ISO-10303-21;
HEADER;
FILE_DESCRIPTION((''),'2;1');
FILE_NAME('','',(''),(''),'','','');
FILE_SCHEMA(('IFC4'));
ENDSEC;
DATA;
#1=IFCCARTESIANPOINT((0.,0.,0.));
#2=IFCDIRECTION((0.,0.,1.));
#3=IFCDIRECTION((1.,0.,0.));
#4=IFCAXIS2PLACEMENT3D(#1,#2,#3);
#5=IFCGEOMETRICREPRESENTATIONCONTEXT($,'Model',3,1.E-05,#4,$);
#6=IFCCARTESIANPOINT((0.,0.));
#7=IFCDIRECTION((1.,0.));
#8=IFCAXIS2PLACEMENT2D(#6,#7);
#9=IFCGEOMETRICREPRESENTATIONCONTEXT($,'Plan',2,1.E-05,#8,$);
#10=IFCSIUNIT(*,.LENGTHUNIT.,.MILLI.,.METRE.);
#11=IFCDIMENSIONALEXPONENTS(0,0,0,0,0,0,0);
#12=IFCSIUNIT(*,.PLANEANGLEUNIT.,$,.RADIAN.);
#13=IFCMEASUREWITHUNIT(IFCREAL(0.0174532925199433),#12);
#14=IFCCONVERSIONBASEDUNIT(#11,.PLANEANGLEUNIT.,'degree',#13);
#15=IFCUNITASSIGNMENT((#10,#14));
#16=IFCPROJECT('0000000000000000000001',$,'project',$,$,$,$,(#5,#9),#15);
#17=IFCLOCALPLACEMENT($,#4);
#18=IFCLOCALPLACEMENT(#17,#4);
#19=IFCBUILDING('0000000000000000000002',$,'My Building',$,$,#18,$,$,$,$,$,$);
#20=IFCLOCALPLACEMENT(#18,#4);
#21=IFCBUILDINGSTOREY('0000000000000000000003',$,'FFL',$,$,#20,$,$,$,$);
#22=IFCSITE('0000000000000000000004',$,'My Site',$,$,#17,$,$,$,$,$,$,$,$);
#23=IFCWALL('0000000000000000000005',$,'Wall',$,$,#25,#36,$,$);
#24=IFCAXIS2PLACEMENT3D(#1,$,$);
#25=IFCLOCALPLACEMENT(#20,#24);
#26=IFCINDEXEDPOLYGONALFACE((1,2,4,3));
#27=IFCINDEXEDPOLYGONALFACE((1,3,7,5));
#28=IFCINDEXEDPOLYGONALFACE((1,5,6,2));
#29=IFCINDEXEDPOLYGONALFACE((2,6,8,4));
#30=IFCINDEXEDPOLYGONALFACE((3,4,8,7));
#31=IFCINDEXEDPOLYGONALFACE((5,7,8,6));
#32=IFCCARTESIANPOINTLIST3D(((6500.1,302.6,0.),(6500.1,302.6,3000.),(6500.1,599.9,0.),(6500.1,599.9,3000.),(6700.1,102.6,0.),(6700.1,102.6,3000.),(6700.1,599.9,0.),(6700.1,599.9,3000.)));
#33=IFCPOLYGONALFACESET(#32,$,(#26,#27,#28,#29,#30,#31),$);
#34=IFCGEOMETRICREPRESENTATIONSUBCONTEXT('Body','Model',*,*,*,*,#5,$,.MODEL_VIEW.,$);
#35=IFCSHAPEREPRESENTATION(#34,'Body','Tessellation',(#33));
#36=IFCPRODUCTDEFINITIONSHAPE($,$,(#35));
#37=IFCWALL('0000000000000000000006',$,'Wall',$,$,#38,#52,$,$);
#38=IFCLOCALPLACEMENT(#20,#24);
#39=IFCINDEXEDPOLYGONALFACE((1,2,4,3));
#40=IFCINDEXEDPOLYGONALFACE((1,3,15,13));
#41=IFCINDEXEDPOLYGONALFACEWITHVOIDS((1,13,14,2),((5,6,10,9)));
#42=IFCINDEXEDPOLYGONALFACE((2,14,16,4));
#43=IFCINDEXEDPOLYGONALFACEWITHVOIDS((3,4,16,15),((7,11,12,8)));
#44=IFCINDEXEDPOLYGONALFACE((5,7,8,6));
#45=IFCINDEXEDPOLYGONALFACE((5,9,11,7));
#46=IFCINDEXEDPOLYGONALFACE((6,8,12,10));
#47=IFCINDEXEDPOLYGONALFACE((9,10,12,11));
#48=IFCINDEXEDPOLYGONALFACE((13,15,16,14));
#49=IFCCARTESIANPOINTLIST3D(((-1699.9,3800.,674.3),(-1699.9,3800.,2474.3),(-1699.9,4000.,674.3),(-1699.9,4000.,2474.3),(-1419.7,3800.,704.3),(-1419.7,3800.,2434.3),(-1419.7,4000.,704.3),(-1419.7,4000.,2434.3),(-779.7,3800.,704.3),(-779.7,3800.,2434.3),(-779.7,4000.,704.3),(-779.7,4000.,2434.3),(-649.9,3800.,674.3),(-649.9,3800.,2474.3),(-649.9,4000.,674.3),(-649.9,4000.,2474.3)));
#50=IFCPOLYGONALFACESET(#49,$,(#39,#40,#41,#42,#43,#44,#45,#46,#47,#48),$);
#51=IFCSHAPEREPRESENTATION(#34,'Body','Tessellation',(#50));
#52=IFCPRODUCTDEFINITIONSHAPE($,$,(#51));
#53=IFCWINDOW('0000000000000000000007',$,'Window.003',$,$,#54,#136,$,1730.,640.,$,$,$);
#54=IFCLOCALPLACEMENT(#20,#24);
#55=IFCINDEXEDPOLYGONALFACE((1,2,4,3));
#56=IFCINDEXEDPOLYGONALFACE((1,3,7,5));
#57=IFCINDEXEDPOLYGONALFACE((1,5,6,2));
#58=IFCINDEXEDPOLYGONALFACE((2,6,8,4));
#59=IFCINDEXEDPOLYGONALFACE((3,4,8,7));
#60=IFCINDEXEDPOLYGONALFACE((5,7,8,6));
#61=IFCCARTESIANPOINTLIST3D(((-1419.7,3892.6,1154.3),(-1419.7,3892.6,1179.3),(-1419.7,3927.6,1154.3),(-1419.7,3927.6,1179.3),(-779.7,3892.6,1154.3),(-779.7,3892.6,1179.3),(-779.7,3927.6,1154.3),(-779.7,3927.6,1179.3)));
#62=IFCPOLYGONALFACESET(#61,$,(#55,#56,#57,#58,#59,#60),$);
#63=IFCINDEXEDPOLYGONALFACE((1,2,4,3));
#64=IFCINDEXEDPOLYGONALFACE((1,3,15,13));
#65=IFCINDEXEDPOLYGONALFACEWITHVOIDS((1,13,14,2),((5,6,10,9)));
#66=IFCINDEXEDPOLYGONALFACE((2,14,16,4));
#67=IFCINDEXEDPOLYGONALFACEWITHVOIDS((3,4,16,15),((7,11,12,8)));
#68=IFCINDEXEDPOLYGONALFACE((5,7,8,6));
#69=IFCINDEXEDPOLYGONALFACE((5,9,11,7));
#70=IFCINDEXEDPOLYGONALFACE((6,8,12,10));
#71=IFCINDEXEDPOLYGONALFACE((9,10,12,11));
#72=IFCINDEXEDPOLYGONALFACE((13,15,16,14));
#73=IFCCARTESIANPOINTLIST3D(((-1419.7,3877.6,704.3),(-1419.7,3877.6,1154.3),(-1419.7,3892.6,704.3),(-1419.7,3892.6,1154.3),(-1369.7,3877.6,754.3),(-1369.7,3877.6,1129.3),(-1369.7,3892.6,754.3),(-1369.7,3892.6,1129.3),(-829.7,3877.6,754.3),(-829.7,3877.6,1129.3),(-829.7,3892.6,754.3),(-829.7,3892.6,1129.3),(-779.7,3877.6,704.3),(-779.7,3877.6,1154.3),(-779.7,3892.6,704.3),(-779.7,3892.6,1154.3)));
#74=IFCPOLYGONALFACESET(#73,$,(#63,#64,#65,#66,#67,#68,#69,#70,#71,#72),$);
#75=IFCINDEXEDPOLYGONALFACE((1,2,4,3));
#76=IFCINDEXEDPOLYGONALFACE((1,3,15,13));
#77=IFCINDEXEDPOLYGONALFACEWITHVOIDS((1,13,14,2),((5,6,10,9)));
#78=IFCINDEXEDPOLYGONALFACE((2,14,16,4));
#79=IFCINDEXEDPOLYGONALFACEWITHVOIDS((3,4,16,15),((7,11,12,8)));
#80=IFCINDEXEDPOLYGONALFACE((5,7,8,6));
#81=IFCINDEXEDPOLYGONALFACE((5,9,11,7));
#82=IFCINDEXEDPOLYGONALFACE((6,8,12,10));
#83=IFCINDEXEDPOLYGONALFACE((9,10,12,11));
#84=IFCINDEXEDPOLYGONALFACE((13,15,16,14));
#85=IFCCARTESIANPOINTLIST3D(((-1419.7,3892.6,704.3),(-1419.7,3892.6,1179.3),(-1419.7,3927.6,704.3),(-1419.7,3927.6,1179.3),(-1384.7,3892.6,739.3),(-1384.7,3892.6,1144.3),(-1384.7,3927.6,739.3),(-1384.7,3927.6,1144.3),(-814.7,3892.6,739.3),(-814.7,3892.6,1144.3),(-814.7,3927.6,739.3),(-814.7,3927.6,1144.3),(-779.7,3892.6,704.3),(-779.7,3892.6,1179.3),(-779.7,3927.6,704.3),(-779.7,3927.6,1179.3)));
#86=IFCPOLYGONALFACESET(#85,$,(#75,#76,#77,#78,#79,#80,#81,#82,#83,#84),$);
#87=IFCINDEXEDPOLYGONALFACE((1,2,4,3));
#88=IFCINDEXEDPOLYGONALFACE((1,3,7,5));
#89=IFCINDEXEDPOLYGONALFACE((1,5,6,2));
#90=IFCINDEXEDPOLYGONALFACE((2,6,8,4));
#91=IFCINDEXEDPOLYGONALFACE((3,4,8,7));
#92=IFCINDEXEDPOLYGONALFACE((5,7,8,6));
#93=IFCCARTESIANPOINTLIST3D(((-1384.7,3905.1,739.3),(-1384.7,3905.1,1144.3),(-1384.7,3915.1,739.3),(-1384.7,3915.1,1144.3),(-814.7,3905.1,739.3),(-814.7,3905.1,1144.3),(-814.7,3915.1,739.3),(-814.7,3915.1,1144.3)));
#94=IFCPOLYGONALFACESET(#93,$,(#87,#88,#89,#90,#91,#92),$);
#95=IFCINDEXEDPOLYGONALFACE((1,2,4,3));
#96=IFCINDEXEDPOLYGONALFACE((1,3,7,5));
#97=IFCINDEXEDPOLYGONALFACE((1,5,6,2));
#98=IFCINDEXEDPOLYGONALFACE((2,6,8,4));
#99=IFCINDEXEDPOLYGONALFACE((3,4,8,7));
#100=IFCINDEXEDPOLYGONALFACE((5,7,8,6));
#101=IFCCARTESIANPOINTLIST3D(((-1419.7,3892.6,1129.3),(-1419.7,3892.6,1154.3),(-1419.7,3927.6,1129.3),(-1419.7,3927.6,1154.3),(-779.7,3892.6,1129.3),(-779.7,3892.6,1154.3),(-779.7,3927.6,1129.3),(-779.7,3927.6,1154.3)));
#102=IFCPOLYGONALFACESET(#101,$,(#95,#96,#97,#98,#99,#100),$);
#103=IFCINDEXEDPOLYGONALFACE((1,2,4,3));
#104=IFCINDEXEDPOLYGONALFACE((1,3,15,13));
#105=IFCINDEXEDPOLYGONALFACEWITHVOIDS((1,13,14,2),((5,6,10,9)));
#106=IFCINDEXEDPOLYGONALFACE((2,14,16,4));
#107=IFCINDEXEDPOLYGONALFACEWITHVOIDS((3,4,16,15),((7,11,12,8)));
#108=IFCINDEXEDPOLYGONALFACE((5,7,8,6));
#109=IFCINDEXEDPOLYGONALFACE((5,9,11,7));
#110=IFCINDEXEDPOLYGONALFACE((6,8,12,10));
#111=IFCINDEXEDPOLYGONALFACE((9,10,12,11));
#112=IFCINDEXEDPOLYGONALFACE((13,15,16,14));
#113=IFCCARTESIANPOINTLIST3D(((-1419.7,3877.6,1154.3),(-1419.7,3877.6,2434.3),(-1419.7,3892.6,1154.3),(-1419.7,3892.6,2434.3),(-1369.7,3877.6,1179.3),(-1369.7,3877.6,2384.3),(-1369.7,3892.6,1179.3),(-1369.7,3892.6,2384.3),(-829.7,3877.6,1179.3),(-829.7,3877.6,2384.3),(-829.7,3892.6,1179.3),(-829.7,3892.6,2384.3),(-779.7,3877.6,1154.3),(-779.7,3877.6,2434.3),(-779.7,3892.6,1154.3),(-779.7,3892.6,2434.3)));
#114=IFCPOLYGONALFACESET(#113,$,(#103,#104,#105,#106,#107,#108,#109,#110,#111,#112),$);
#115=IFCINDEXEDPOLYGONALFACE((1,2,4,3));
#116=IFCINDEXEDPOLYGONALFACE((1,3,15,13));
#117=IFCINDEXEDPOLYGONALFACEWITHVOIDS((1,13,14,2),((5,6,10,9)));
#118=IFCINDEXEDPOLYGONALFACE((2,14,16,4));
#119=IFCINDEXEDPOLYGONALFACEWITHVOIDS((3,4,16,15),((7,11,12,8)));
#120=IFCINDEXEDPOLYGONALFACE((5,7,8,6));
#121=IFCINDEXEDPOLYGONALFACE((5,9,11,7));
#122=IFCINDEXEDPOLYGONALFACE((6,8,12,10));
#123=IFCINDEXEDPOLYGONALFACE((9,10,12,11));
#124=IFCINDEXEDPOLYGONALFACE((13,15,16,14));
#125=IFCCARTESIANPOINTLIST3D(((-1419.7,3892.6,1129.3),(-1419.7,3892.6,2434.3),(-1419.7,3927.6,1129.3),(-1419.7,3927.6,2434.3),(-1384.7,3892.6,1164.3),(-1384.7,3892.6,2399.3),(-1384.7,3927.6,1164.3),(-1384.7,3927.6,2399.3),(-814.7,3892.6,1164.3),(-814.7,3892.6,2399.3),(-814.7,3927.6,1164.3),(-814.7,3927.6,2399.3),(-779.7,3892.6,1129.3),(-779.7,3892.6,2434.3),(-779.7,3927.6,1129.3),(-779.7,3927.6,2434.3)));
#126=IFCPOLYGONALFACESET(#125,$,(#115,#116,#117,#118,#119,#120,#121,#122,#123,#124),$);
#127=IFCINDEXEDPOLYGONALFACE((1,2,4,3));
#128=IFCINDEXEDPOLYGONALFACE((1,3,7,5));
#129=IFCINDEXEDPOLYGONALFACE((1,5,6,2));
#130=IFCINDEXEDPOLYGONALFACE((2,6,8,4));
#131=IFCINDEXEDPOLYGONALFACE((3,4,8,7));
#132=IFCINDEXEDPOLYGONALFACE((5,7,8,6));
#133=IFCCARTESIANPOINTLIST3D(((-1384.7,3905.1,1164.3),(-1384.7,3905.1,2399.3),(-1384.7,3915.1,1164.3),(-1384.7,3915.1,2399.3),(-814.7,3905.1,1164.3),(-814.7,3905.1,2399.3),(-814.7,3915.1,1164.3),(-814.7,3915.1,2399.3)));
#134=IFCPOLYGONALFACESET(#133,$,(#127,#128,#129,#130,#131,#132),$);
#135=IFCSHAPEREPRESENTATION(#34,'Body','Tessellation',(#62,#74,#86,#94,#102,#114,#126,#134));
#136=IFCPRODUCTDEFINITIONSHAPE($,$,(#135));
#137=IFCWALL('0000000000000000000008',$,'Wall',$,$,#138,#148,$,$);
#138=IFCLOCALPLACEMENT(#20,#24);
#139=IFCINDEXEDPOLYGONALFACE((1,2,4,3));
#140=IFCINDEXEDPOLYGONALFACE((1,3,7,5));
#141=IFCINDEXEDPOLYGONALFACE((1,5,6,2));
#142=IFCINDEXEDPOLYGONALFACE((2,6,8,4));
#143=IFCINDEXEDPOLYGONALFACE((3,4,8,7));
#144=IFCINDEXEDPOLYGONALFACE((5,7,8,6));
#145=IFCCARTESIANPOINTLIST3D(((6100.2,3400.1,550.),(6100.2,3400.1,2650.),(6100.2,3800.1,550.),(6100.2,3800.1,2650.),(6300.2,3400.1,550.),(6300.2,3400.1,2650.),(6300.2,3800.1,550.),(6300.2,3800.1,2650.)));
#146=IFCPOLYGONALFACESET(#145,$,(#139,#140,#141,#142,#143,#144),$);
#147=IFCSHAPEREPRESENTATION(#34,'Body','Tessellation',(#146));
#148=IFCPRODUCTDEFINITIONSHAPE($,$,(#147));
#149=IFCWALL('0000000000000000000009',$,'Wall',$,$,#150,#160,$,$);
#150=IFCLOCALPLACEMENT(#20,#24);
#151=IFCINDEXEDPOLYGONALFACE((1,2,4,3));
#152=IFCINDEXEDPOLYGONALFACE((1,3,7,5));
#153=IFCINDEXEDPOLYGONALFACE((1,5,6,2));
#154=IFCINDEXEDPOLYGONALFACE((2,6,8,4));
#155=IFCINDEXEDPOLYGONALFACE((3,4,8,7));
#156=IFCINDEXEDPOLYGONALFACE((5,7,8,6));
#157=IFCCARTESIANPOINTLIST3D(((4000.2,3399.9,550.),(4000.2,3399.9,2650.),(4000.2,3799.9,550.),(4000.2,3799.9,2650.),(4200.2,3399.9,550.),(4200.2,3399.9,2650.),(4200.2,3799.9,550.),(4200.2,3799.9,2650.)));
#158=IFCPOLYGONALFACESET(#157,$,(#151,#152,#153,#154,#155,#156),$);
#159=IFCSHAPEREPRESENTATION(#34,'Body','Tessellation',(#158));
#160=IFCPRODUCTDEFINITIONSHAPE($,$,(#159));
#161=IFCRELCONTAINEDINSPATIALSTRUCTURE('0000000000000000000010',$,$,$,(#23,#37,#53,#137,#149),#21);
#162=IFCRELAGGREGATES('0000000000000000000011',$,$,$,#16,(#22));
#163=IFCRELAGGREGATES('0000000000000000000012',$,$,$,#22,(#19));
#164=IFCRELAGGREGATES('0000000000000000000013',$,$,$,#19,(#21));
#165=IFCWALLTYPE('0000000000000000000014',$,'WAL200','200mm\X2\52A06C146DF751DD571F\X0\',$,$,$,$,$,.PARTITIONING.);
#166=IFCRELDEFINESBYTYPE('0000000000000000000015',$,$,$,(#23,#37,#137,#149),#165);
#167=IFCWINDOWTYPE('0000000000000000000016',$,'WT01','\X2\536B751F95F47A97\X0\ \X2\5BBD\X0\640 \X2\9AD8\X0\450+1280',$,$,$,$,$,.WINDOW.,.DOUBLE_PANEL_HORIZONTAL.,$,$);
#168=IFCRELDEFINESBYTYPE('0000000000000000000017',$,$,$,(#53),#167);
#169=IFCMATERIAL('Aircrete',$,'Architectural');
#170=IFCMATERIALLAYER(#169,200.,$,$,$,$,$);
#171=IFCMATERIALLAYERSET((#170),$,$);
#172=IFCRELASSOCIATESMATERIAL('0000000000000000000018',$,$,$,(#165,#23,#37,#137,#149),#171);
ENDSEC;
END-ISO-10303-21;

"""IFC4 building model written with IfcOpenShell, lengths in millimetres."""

from ifc_helpers import new_model, entity, si_unit, converted_unit, frame, origin_with_axes, origin_2d_with_axis, place, context, subcontext, project, spatial, line, indexed_curve, outline, extrude, shape, source, transform, mapped, material, layer, layer_set, layer_usage, type_object, type_shapes, element, fill, save


model = new_model("IFC4")

# Units and contexts
model_context = context("Model", 3, precision=1e-05, world=origin_with_axes())
plan_context = context("Plan", 2, precision=1e-05, world=origin_2d_with_axis())
body_context_1 = subcontext(model_context, "Body", "Model", "MODEL_VIEW")
body_context_2 = subcontext(plan_context, "Body", "Plan", "PLAN_VIEW")
ifc_project = project(units=[si_unit("LENGTHUNIT", "METRE", prefix="MILLI"), converted_unit("PLANEANGLEUNIT", "degree", entity("IfcReal", 0.0174532925199433), si_unit("PLANEANGLEUNIT", "RADIAN"), dimensions=[0, 0, 0, 0, 0, 0, 0])], contexts=[model_context, plan_context])

# Site, building, storey
site_placement = place(None, origin_with_axes())
site = spatial("IfcSite", under=ifc_project, at=site_placement, Name="My Site")
building_placement = place(site_placement, origin_with_axes())
building = spatial("IfcBuilding", under=site, at=building_placement, Name="My Building")
storey_placement = place(building_placement, origin_with_axes())
storey = spatial("IfcBuildingStorey", under=building, at=storey_placement, Name="FFL")

# Shared definitions
ifc_material_1 = material(Name="Aircrete", Category="Architectural")

# Shared definitions
ifc_layer_1 = layer(ifc_material_1, 200.0)
ifc_layer_set_1 = layer_set([ifc_layer_1])
wall_type_1 = type_object("IfcWallType", Name="WAL200", Description="200mm加气混凝土", PredefinedType="PARTITIONING", material=ifc_layer_set_1)

# Wall
ifc_layer_usage_1 = layer_usage(ifc_layer_set_1, "AXIS2", "NEGATIVE", 0.0)
wall_1_placement = place(storey_placement, frame((6700.1, 599.9, 0.0), z_axis=(0.0, 0.0, 1.0), x_axis=(-0.000001, -1.0, 0.0)))
element("IfcWall", 1, at=wall_1_placement, inside=storey, type_object=wall_type_1, material=ifc_layer_usage_1, Name="Wall", context=body_context_1, shape_type="SweptSolid", body=[
    extrude(outline(indexed_curve([(0.0, -200.0), (0.0, 0.0), (497.3, 0.0), (297.3, -200.0)], segments=[line(1, 2, 3, 4, 1)])), origin_with_axes(), (0.0, 0.0, 1.0), 3000.0),
])

# Wall, opening, window
ifc_layer_usage_2 = layer_usage(ifc_layer_set_1, "AXIS2", "NEGATIVE", 0.0)
wall_2_placement = place(storey_placement, frame((-1699.9, 4000.0, 674.3), z_axis=(0.0, 0.0, 1.0), x_axis=(1.0, 0.0, 0.0)))
wall_2 = element("IfcWall", 2, at=wall_2_placement, inside=storey, type_object=wall_type_1, material=ifc_layer_usage_2, Name="Wall", context=body_context_1, shape_type="SweptSolid", body=[
    extrude(outline(indexed_curve([(0.0, -200.0), (0.0, 0.0), (1050.0, 0.0), (1050.0, -200.0)], segments=[line(1, 2, 3, 4, 1)])), origin_with_axes(), (0.0, 0.0, 1.0), 1800.0),
])
shared_shape_1 = source(origin_with_axes(), body_context_1, "Body", "SweptSolid", [
    extrude(outline(indexed_curve([(0.0, 0.0), (640.0, 0.0), (640.0, 1730.0), (0.0, 1730.0)], segments=[line(1, 2, 3, 4, 1)])), frame((0.0, -600.0, 0.0), z_axis=(0.0, -1.0, 0.0), x_axis=(1.0, 0.0, 0.0)), (0.0, 0.0, -1.0), 1200.0),
])
opening_1_placement = place(wall_2_placement, frame((280.2, -172.4, 30.0), z_axis=(0.0, 0.0, 1.0), x_axis=(1.0, 0.0, 0.0)))
opening_1 = element("IfcOpeningElement", 3, at=opening_1_placement, cuts=wall_2, PredefinedType="OPENING", context=body_context_1, shape_type="MappedRepresentation", body=[
    mapped(shared_shape_1, transform((0.0, 0.0, 0.0), x_axis=(1.0, 0.0, 0.0), y_axis=(0.0, 1.0, 0.0), z_axis=(0.0, 0.0, 1.0), scale=1.0)),
])
window_type_1 = type_object("IfcWindowType", Name="WT01", Description="卫生间窗 宽640 高450+1280", PartitioningType="DOUBLE_PANEL_HORIZONTAL", PredefinedType="WINDOW")
shared_shape_2 = source(origin_with_axes(), body_context_1, "Body", "SweptSolid", [
    extrude(outline(indexed_curve([(0.0, 450.0), (640.0, 450.0), (640.0, 475.0), (0.0, 475.0)], segments=[line(1, 2, 3, 4, 1)])), frame((0.0, 65.0, 0.0), z_axis=(0.0, -1.0, 0.0), x_axis=(1.0, 0.0, 0.0)), (0.0, 0.0, -1.0), 35.0),
    extrude(outline(indexed_curve([(0.0, 0.0), (640.0, 0.0), (640.0, 450.0), (0.0, 450.0)], segments=[line(1, 2, 3, 4, 1)]), holes=[indexed_curve([(50.0, 50.0), (590.0, 50.0), (590.0, 425.0), (50.0, 425.0)], segments=[line(1, 2, 3, 4, 1)])]), frame((0.0, 50.0, 0.0), z_axis=(0.0, -1.0, 0.0), x_axis=(1.0, 0.0, 0.0)), (0.0, 0.0, -1.0), 15.0),
    extrude(outline(indexed_curve([(0.0, 0.0), (640.0, 0.0), (640.0, 475.0), (0.0, 475.0)], segments=[line(1, 2, 3, 4, 1)]), holes=[indexed_curve([(35.0, 35.0), (605.0, 35.0), (605.0, 440.0), (35.0, 440.0)], segments=[line(1, 2, 3, 4, 1)])]), frame((0.0, 65.0, 0.0), z_axis=(0.0, -1.0, 0.0), x_axis=(1.0, 0.0, 0.0)), (0.0, 0.0, -1.0), 35.0),
    extrude(outline(indexed_curve([(35.0, 35.0), (605.0, 35.0), (605.0, 440.0), (35.0, 440.0)], segments=[line(1, 2, 3, 4, 1)])), frame((0.0, 77.5, 0.0), z_axis=(0.0, -1.0, 0.0), x_axis=(1.0, 0.0, 0.0)), (0.0, 0.0, -1.0), 10.0),
    extrude(outline(indexed_curve([(640.0, 0.0), (0.0, 0.0), (0.0, -25.0), (640.0, -25.0)], segments=[line(1, 2, 3, 4, 1)])), frame((0.0, 65.0, 450.0), z_axis=(0.0, -1.0, 0.0), x_axis=(1.0, 0.0, 0.0)), (0.0, 0.0, -1.0), 35.0),
    extrude(outline(indexed_curve([(0.0, 0.0), (640.0, 0.0), (640.0, 1280.0), (0.0, 1280.0), (0.0, 0.0)]), holes=[indexed_curve([(50.0, 25.0), (590.0, 25.0), (590.0, 1230.0), (50.0, 1230.0), (50.0, 25.0)])]), frame((0.0, 50.0, 450.0), z_axis=(0.0, -1.0, 0.0), x_axis=(1.0, 0.0, 0.0)), (0.0, 0.0, -1.0), 15.0),
    extrude(outline(indexed_curve([(0.0, 0.0), (640.0, 0.0), (640.0, 1305.0), (0.0, 1305.0)], segments=[line(1, 2, 3, 4, 1)]), holes=[indexed_curve([(35.0, 35.0), (605.0, 35.0), (605.0, 1270.0), (35.0, 1270.0)], segments=[line(1, 2, 3, 4, 1)])]), frame((0.0, 65.0, 425.0), z_axis=(0.0, -1.0, 0.0), x_axis=(1.0, 0.0, 0.0)), (0.0, 0.0, -1.0), 35.0),
    extrude(outline(indexed_curve([(35.0, 35.0), (605.0, 35.0), (605.0, 1270.0), (35.0, 1270.0)], segments=[line(1, 2, 3, 4, 1)])), frame((0.0, 77.5, 425.0), z_axis=(0.0, -1.0, 0.0), x_axis=(1.0, 0.0, 0.0)), (0.0, 0.0, -1.0), 10.0),
])
shared_shape_3 = source(origin_with_axes(), body_context_2, "Body", "Curve2D", [
    entity("IfcIndexedPolyCurve", entity("IfcCartesianPointList2D", [[50.0, 50.0], [590.0, 50.0]])),
    entity("IfcIndexedPolyCurve", entity("IfcCartesianPointList2D", [[0.0, 100.0], [0.0, 100.0], [0.0, 65.0], [50.0, 65.0], [50.0, 50.0], [0.0, 50.0]]), [entity("IfcLineIndex", [1, 2, 3, 4, 5, 6, 1])]),
    entity("IfcIndexedPolyCurve", entity("IfcCartesianPointList2D", [[640.0, 100.0], [640.0, 100.0], [640.0, 65.0], [590.0, 65.0], [590.0, 50.0], [640.0, 50.0]]), [entity("IfcLineIndex", [1, 2, 3, 4, 5, 6, 1])]),
    entity("IfcIndexedPolyCurve", entity("IfcCartesianPointList2D", [[0.0, 65.0], [35.0, 65.0], [35.0, 100.0], [0.0, 100.0]]), [entity("IfcLineIndex", [1, 2, 3, 4, 1])]),
    entity("IfcIndexedPolyCurve", entity("IfcCartesianPointList2D", [[640.0, 65.0], [605.0, 65.0], [605.0, 100.0], [640.0, 100.0]]), [entity("IfcLineIndex", [1, 2, 3, 4, 1])]),
    entity("IfcIndexedPolyCurve", entity("IfcCartesianPointList2D", [[35.0, 65.0], [605.0, 65.0]])),
    entity("IfcIndexedPolyCurve", entity("IfcCartesianPointList2D", [[35.0, 100.0], [605.0, 100.0]])),
    entity("IfcIndexedPolyCurve", entity("IfcCartesianPointList2D", [[35.0, 82.5], [605.0, 82.5]])),
])
type_shapes(window_type_1, [shared_shape_2, shared_shape_3])
window_1_placement = place(opening_1_placement, origin_with_axes())
window_1 = element("IfcWindow", 4, at=window_1_placement, inside=storey, type_object=window_type_1, Name="Window.003", OverallHeight=1730.0, OverallWidth=640.0, shapes=[
    shape(body_context_1, "Body", "MappedRepresentation", [mapped(shared_shape_2, transform((0.0, 0.0, 0.0), x_axis=(1.0, 0.0, 0.0), y_axis=(0.0, 1.0, 0.0), z_axis=(0.0, 0.0, 1.0), scale=1.0))]),
    shape(body_context_2, "Body", "MappedRepresentation", [mapped(shared_shape_3, transform((0.0, 0.0, 0.0), x_axis=(1.0, 0.0, 0.0), y_axis=(0.0, 1.0, 0.0), z_axis=(0.0, 0.0, 1.0), scale=1.0))]),
])
fill(opening_1, window_1)

# Walls
ifc_layer_usage_3 = layer_usage(ifc_layer_set_1, "AXIS2", "NEGATIVE", 0.0)
wall_3_placement = place(storey_placement, frame((6100.2, 3400.1, 550.0), z_axis=(0.0, 0.0, 1.0), x_axis=(0.0, 1.0, 0.0)))
element("IfcWall", 5, at=wall_3_placement, inside=storey, type_object=wall_type_1, material=ifc_layer_usage_3, Name="Wall", context=body_context_1, shape_type="SweptSolid", body=[
    extrude(outline(indexed_curve([(0.0, -200.0), (0.0, 0.0), (400.0, 0.0), (400.0, -200.0)], segments=[line(1, 2, 3, 4, 1)])), origin_with_axes(), (0.0, 0.0, 1.0), 2100.0),
])
ifc_layer_usage_4 = layer_usage(ifc_layer_set_1, "AXIS2", "NEGATIVE", 0.0)
wall_4_placement = place(storey_placement, frame((4200.2, 3799.9, 550.0), z_axis=(0.0, 0.0, 1.0), x_axis=(0.0, -1.0, 0.0)))
element("IfcWall", 6, at=wall_4_placement, inside=storey, type_object=wall_type_1, material=ifc_layer_usage_4, Name="Wall", context=body_context_1, shape_type="SweptSolid", body=[
    extrude(outline(indexed_curve([(0.0, -200.0), (0.0, 0.0), (400.0, 0.0), (400.0, -200.0)], segments=[line(1, 2, 3, 4, 1)])), origin_with_axes(), (0.0, 0.0, 1.0), 2100.0),
])

save(model, "model.ifc")
